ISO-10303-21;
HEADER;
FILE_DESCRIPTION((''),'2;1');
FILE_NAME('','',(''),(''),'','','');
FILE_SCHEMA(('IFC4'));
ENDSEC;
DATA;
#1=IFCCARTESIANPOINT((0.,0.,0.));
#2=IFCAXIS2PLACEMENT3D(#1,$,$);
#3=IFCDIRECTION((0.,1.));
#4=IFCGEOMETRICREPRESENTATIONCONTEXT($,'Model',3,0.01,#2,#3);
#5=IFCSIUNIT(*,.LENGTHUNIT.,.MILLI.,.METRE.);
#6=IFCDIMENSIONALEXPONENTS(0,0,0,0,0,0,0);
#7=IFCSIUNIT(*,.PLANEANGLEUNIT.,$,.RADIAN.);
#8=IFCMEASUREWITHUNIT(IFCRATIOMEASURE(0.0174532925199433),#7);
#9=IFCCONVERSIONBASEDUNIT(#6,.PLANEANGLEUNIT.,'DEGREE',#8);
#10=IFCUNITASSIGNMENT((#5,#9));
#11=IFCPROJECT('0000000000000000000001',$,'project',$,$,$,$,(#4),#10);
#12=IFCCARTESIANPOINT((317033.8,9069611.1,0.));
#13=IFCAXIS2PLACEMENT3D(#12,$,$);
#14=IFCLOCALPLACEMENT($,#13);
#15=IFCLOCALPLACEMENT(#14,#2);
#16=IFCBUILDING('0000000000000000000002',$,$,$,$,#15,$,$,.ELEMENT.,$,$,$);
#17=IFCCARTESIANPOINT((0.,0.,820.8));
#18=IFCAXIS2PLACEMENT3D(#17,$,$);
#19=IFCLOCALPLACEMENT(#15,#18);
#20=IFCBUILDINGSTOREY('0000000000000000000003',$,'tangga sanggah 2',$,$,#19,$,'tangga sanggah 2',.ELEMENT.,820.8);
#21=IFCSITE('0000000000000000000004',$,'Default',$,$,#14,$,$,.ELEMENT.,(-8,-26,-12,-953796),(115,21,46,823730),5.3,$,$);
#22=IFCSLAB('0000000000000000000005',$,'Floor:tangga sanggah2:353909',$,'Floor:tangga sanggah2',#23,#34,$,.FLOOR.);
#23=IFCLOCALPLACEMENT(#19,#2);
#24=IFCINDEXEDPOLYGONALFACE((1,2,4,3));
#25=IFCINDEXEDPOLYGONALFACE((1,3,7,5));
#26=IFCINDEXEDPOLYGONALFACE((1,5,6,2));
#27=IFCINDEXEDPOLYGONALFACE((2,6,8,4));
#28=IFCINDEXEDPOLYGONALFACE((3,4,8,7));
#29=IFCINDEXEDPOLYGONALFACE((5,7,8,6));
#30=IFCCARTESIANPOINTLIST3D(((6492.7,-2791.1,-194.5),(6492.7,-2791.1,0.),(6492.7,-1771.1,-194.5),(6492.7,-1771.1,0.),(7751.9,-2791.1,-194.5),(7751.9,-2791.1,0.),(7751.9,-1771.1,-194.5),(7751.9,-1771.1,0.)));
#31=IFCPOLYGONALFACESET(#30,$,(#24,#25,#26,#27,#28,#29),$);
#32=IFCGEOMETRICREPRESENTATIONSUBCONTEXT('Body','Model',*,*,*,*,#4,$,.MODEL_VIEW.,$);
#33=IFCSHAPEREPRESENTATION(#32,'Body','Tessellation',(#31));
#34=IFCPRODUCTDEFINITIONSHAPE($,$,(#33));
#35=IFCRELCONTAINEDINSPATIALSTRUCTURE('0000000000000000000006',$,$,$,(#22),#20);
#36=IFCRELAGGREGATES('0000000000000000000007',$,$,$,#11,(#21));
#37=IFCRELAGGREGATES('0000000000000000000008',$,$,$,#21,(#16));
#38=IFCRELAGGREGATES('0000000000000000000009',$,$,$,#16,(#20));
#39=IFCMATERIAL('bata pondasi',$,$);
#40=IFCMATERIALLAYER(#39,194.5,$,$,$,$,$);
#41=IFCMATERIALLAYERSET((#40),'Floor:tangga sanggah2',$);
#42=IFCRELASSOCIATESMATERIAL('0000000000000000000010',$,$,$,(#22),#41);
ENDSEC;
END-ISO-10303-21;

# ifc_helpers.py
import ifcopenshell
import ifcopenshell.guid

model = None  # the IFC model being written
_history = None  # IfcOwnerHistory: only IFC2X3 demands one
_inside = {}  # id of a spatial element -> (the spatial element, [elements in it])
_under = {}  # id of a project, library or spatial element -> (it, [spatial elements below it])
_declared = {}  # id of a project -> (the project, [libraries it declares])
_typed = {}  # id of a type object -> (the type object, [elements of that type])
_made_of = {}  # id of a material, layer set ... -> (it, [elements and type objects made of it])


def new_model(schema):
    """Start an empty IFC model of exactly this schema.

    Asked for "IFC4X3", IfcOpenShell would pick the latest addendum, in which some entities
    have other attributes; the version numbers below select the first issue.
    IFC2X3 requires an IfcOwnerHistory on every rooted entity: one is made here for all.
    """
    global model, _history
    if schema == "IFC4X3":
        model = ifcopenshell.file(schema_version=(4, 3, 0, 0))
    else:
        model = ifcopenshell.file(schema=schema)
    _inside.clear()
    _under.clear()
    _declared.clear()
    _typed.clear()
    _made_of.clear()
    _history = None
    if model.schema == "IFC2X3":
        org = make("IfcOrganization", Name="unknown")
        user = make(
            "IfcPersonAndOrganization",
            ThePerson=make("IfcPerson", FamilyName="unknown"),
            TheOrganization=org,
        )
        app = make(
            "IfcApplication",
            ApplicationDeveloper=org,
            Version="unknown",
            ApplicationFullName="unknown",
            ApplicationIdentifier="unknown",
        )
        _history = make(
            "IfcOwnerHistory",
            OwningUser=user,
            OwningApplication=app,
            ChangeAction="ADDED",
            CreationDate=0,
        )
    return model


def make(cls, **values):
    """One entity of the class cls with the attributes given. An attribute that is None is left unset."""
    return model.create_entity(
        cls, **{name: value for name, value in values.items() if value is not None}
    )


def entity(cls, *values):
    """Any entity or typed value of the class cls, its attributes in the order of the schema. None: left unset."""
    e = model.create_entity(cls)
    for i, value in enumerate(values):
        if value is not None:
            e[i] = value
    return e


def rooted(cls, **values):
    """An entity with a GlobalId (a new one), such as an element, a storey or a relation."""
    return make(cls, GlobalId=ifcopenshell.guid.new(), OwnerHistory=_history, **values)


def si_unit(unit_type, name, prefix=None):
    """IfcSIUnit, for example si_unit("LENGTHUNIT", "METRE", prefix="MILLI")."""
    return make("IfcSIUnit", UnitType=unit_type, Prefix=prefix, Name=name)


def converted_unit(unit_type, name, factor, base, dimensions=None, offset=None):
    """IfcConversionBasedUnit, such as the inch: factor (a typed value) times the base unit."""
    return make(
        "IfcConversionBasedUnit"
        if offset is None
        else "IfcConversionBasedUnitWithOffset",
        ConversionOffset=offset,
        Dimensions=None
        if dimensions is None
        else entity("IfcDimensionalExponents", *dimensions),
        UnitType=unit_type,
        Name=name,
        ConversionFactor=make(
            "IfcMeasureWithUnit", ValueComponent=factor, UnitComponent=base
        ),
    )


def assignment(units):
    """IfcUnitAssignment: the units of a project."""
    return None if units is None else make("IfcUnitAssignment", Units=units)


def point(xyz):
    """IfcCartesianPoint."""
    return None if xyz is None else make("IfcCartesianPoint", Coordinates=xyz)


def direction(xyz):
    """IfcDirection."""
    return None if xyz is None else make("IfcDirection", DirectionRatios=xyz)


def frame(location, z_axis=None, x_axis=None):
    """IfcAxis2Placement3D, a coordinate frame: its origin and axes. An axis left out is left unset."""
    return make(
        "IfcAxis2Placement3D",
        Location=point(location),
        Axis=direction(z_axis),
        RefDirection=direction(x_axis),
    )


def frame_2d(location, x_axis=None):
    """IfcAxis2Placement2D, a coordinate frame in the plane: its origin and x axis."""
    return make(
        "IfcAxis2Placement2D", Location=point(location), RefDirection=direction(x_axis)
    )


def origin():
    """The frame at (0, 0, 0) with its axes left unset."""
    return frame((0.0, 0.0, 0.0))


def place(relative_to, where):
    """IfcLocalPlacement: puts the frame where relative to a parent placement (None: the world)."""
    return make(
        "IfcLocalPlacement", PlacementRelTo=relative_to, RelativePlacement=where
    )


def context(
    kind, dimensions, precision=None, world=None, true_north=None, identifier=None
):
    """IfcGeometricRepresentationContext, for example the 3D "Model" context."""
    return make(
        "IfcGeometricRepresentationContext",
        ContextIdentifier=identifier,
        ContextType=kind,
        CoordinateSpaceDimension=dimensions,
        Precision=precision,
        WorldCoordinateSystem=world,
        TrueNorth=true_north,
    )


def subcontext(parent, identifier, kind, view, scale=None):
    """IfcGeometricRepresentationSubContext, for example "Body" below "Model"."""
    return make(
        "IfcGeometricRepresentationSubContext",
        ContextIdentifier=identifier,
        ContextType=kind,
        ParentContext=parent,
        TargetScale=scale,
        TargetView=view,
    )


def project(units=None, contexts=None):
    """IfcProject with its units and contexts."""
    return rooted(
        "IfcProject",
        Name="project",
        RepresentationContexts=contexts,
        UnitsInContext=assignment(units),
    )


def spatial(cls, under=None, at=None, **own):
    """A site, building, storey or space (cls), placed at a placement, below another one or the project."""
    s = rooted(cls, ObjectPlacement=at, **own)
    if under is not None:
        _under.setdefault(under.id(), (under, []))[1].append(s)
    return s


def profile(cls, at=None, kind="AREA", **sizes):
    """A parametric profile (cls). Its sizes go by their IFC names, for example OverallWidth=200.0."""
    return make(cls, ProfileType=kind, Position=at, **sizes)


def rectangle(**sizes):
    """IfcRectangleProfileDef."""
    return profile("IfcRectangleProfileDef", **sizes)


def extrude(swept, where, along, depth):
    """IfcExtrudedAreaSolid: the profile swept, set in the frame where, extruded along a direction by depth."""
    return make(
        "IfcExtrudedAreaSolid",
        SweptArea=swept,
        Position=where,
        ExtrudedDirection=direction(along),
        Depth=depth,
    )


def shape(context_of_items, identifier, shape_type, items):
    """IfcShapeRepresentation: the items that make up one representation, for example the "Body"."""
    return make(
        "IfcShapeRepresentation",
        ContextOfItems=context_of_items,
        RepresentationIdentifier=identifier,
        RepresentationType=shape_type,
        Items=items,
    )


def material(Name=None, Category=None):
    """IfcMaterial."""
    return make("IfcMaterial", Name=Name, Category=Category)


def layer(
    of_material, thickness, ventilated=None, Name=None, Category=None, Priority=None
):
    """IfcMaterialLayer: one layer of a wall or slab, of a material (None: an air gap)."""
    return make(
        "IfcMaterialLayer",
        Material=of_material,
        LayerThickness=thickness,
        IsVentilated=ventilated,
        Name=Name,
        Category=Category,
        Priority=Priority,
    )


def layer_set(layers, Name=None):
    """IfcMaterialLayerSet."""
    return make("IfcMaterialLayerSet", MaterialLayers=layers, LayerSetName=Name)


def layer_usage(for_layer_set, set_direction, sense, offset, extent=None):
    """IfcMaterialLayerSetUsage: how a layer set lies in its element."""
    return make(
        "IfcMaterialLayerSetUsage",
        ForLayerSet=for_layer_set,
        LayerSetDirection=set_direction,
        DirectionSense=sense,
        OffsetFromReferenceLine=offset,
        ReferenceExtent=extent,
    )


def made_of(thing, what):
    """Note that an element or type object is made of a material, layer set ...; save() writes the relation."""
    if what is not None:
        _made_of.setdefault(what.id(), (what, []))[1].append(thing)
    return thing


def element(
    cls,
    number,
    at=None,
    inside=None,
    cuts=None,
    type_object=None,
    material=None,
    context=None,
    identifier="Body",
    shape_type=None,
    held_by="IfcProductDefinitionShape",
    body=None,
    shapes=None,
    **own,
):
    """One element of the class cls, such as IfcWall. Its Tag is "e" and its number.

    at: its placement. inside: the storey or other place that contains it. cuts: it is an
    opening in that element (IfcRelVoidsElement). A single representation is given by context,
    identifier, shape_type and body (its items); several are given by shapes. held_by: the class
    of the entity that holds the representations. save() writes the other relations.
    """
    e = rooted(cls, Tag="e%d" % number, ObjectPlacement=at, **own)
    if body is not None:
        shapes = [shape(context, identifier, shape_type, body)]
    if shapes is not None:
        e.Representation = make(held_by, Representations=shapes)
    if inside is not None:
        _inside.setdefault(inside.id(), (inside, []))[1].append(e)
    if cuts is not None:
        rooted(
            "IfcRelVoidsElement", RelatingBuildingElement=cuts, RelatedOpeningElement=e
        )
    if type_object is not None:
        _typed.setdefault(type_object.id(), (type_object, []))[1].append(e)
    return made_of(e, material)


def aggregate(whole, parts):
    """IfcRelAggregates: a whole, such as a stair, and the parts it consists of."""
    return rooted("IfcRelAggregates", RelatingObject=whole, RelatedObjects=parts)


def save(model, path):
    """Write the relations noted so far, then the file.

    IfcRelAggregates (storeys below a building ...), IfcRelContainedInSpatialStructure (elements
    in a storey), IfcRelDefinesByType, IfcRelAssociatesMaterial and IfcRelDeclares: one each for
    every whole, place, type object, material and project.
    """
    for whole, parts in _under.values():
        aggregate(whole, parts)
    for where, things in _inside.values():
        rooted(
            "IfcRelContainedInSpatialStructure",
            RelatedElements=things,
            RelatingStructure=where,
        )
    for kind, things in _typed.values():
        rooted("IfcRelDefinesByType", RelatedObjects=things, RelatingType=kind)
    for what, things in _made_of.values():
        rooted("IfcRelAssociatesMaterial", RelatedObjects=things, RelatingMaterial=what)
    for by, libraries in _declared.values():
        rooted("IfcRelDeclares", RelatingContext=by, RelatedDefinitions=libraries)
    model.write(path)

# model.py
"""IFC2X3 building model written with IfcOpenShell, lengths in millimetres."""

from ifc_helpers import new_model, entity, si_unit, converted_unit, direction, frame, frame_2d, origin, place, context, subcontext, project, spatial, rectangle, extrude, material, layer, layer_set, layer_usage, element, save


model = new_model("IFC2X3")

# Units and contexts
model_context = context("Model", 3, precision=0.01, world=origin(), true_north=direction((0.0, 1.0)))
body_context = subcontext(model_context, "Body", "Model", "MODEL_VIEW")
ifc_project = project(units=[si_unit("LENGTHUNIT", "METRE", prefix="MILLI"), converted_unit("PLANEANGLEUNIT", "DEGREE", entity("IfcRatioMeasure", 0.0174532925199433), si_unit("PLANEANGLEUNIT", "RADIAN"), dimensions=[0, 0, 0, 0, 0, 0, 0])], contexts=[model_context])

# Site, building, storey
site_placement = place(None, frame((317033.8, 9069611.1, 0.0)))
site = spatial("IfcSite", under=ifc_project, at=site_placement, Name="Default", CompositionType="ELEMENT", RefLatitude=(-8, -26, -12, -953796), RefLongitude=(115, 21, 46, 823730), RefElevation=5.3)
building_placement = place(site_placement, origin())
building = spatial("IfcBuilding", under=site, at=building_placement, CompositionType="ELEMENT")
storey_placement = place(building_placement, frame((0.0, 0.0, 820.8)))
storey = spatial("IfcBuildingStorey", under=building, at=storey_placement, Name="tangga sanggah 2", LongName="tangga sanggah 2", CompositionType="ELEMENT", Elevation=820.8)

# Slab
ifc_material_1 = material(Name="bata pondasi")
ifc_layer_1 = layer(ifc_material_1, 194.5)
ifc_layer_set_1 = layer_set([ifc_layer_1], Name="Floor:tangga sanggah2")
ifc_layer_usage_1 = layer_usage(ifc_layer_set_1, "AXIS3", "POSITIVE", 0.0)
slab_1_placement = place(storey_placement, origin())
element("IfcSlab", 1, at=slab_1_placement, inside=storey, material=ifc_layer_usage_1, Name="Floor:tangga sanggah2:353909", ObjectType="Floor:tangga sanggah2", PredefinedType="FLOOR", context=body_context, shape_type="SweptSolid", body=[
    extrude(rectangle(XDim=1020.0, YDim=1259.2, at=frame_2d((0.0, 0.0), x_axis=(1.0, 0.0))), frame((7122.3, -2281.1, 0.0), z_axis=(0.0, 0.0, -1.0), x_axis=(0.0, 1.0, 0.0)), (0.0, 0.0, 1.0), 194.5),
])

save(model, "model.ifc")
